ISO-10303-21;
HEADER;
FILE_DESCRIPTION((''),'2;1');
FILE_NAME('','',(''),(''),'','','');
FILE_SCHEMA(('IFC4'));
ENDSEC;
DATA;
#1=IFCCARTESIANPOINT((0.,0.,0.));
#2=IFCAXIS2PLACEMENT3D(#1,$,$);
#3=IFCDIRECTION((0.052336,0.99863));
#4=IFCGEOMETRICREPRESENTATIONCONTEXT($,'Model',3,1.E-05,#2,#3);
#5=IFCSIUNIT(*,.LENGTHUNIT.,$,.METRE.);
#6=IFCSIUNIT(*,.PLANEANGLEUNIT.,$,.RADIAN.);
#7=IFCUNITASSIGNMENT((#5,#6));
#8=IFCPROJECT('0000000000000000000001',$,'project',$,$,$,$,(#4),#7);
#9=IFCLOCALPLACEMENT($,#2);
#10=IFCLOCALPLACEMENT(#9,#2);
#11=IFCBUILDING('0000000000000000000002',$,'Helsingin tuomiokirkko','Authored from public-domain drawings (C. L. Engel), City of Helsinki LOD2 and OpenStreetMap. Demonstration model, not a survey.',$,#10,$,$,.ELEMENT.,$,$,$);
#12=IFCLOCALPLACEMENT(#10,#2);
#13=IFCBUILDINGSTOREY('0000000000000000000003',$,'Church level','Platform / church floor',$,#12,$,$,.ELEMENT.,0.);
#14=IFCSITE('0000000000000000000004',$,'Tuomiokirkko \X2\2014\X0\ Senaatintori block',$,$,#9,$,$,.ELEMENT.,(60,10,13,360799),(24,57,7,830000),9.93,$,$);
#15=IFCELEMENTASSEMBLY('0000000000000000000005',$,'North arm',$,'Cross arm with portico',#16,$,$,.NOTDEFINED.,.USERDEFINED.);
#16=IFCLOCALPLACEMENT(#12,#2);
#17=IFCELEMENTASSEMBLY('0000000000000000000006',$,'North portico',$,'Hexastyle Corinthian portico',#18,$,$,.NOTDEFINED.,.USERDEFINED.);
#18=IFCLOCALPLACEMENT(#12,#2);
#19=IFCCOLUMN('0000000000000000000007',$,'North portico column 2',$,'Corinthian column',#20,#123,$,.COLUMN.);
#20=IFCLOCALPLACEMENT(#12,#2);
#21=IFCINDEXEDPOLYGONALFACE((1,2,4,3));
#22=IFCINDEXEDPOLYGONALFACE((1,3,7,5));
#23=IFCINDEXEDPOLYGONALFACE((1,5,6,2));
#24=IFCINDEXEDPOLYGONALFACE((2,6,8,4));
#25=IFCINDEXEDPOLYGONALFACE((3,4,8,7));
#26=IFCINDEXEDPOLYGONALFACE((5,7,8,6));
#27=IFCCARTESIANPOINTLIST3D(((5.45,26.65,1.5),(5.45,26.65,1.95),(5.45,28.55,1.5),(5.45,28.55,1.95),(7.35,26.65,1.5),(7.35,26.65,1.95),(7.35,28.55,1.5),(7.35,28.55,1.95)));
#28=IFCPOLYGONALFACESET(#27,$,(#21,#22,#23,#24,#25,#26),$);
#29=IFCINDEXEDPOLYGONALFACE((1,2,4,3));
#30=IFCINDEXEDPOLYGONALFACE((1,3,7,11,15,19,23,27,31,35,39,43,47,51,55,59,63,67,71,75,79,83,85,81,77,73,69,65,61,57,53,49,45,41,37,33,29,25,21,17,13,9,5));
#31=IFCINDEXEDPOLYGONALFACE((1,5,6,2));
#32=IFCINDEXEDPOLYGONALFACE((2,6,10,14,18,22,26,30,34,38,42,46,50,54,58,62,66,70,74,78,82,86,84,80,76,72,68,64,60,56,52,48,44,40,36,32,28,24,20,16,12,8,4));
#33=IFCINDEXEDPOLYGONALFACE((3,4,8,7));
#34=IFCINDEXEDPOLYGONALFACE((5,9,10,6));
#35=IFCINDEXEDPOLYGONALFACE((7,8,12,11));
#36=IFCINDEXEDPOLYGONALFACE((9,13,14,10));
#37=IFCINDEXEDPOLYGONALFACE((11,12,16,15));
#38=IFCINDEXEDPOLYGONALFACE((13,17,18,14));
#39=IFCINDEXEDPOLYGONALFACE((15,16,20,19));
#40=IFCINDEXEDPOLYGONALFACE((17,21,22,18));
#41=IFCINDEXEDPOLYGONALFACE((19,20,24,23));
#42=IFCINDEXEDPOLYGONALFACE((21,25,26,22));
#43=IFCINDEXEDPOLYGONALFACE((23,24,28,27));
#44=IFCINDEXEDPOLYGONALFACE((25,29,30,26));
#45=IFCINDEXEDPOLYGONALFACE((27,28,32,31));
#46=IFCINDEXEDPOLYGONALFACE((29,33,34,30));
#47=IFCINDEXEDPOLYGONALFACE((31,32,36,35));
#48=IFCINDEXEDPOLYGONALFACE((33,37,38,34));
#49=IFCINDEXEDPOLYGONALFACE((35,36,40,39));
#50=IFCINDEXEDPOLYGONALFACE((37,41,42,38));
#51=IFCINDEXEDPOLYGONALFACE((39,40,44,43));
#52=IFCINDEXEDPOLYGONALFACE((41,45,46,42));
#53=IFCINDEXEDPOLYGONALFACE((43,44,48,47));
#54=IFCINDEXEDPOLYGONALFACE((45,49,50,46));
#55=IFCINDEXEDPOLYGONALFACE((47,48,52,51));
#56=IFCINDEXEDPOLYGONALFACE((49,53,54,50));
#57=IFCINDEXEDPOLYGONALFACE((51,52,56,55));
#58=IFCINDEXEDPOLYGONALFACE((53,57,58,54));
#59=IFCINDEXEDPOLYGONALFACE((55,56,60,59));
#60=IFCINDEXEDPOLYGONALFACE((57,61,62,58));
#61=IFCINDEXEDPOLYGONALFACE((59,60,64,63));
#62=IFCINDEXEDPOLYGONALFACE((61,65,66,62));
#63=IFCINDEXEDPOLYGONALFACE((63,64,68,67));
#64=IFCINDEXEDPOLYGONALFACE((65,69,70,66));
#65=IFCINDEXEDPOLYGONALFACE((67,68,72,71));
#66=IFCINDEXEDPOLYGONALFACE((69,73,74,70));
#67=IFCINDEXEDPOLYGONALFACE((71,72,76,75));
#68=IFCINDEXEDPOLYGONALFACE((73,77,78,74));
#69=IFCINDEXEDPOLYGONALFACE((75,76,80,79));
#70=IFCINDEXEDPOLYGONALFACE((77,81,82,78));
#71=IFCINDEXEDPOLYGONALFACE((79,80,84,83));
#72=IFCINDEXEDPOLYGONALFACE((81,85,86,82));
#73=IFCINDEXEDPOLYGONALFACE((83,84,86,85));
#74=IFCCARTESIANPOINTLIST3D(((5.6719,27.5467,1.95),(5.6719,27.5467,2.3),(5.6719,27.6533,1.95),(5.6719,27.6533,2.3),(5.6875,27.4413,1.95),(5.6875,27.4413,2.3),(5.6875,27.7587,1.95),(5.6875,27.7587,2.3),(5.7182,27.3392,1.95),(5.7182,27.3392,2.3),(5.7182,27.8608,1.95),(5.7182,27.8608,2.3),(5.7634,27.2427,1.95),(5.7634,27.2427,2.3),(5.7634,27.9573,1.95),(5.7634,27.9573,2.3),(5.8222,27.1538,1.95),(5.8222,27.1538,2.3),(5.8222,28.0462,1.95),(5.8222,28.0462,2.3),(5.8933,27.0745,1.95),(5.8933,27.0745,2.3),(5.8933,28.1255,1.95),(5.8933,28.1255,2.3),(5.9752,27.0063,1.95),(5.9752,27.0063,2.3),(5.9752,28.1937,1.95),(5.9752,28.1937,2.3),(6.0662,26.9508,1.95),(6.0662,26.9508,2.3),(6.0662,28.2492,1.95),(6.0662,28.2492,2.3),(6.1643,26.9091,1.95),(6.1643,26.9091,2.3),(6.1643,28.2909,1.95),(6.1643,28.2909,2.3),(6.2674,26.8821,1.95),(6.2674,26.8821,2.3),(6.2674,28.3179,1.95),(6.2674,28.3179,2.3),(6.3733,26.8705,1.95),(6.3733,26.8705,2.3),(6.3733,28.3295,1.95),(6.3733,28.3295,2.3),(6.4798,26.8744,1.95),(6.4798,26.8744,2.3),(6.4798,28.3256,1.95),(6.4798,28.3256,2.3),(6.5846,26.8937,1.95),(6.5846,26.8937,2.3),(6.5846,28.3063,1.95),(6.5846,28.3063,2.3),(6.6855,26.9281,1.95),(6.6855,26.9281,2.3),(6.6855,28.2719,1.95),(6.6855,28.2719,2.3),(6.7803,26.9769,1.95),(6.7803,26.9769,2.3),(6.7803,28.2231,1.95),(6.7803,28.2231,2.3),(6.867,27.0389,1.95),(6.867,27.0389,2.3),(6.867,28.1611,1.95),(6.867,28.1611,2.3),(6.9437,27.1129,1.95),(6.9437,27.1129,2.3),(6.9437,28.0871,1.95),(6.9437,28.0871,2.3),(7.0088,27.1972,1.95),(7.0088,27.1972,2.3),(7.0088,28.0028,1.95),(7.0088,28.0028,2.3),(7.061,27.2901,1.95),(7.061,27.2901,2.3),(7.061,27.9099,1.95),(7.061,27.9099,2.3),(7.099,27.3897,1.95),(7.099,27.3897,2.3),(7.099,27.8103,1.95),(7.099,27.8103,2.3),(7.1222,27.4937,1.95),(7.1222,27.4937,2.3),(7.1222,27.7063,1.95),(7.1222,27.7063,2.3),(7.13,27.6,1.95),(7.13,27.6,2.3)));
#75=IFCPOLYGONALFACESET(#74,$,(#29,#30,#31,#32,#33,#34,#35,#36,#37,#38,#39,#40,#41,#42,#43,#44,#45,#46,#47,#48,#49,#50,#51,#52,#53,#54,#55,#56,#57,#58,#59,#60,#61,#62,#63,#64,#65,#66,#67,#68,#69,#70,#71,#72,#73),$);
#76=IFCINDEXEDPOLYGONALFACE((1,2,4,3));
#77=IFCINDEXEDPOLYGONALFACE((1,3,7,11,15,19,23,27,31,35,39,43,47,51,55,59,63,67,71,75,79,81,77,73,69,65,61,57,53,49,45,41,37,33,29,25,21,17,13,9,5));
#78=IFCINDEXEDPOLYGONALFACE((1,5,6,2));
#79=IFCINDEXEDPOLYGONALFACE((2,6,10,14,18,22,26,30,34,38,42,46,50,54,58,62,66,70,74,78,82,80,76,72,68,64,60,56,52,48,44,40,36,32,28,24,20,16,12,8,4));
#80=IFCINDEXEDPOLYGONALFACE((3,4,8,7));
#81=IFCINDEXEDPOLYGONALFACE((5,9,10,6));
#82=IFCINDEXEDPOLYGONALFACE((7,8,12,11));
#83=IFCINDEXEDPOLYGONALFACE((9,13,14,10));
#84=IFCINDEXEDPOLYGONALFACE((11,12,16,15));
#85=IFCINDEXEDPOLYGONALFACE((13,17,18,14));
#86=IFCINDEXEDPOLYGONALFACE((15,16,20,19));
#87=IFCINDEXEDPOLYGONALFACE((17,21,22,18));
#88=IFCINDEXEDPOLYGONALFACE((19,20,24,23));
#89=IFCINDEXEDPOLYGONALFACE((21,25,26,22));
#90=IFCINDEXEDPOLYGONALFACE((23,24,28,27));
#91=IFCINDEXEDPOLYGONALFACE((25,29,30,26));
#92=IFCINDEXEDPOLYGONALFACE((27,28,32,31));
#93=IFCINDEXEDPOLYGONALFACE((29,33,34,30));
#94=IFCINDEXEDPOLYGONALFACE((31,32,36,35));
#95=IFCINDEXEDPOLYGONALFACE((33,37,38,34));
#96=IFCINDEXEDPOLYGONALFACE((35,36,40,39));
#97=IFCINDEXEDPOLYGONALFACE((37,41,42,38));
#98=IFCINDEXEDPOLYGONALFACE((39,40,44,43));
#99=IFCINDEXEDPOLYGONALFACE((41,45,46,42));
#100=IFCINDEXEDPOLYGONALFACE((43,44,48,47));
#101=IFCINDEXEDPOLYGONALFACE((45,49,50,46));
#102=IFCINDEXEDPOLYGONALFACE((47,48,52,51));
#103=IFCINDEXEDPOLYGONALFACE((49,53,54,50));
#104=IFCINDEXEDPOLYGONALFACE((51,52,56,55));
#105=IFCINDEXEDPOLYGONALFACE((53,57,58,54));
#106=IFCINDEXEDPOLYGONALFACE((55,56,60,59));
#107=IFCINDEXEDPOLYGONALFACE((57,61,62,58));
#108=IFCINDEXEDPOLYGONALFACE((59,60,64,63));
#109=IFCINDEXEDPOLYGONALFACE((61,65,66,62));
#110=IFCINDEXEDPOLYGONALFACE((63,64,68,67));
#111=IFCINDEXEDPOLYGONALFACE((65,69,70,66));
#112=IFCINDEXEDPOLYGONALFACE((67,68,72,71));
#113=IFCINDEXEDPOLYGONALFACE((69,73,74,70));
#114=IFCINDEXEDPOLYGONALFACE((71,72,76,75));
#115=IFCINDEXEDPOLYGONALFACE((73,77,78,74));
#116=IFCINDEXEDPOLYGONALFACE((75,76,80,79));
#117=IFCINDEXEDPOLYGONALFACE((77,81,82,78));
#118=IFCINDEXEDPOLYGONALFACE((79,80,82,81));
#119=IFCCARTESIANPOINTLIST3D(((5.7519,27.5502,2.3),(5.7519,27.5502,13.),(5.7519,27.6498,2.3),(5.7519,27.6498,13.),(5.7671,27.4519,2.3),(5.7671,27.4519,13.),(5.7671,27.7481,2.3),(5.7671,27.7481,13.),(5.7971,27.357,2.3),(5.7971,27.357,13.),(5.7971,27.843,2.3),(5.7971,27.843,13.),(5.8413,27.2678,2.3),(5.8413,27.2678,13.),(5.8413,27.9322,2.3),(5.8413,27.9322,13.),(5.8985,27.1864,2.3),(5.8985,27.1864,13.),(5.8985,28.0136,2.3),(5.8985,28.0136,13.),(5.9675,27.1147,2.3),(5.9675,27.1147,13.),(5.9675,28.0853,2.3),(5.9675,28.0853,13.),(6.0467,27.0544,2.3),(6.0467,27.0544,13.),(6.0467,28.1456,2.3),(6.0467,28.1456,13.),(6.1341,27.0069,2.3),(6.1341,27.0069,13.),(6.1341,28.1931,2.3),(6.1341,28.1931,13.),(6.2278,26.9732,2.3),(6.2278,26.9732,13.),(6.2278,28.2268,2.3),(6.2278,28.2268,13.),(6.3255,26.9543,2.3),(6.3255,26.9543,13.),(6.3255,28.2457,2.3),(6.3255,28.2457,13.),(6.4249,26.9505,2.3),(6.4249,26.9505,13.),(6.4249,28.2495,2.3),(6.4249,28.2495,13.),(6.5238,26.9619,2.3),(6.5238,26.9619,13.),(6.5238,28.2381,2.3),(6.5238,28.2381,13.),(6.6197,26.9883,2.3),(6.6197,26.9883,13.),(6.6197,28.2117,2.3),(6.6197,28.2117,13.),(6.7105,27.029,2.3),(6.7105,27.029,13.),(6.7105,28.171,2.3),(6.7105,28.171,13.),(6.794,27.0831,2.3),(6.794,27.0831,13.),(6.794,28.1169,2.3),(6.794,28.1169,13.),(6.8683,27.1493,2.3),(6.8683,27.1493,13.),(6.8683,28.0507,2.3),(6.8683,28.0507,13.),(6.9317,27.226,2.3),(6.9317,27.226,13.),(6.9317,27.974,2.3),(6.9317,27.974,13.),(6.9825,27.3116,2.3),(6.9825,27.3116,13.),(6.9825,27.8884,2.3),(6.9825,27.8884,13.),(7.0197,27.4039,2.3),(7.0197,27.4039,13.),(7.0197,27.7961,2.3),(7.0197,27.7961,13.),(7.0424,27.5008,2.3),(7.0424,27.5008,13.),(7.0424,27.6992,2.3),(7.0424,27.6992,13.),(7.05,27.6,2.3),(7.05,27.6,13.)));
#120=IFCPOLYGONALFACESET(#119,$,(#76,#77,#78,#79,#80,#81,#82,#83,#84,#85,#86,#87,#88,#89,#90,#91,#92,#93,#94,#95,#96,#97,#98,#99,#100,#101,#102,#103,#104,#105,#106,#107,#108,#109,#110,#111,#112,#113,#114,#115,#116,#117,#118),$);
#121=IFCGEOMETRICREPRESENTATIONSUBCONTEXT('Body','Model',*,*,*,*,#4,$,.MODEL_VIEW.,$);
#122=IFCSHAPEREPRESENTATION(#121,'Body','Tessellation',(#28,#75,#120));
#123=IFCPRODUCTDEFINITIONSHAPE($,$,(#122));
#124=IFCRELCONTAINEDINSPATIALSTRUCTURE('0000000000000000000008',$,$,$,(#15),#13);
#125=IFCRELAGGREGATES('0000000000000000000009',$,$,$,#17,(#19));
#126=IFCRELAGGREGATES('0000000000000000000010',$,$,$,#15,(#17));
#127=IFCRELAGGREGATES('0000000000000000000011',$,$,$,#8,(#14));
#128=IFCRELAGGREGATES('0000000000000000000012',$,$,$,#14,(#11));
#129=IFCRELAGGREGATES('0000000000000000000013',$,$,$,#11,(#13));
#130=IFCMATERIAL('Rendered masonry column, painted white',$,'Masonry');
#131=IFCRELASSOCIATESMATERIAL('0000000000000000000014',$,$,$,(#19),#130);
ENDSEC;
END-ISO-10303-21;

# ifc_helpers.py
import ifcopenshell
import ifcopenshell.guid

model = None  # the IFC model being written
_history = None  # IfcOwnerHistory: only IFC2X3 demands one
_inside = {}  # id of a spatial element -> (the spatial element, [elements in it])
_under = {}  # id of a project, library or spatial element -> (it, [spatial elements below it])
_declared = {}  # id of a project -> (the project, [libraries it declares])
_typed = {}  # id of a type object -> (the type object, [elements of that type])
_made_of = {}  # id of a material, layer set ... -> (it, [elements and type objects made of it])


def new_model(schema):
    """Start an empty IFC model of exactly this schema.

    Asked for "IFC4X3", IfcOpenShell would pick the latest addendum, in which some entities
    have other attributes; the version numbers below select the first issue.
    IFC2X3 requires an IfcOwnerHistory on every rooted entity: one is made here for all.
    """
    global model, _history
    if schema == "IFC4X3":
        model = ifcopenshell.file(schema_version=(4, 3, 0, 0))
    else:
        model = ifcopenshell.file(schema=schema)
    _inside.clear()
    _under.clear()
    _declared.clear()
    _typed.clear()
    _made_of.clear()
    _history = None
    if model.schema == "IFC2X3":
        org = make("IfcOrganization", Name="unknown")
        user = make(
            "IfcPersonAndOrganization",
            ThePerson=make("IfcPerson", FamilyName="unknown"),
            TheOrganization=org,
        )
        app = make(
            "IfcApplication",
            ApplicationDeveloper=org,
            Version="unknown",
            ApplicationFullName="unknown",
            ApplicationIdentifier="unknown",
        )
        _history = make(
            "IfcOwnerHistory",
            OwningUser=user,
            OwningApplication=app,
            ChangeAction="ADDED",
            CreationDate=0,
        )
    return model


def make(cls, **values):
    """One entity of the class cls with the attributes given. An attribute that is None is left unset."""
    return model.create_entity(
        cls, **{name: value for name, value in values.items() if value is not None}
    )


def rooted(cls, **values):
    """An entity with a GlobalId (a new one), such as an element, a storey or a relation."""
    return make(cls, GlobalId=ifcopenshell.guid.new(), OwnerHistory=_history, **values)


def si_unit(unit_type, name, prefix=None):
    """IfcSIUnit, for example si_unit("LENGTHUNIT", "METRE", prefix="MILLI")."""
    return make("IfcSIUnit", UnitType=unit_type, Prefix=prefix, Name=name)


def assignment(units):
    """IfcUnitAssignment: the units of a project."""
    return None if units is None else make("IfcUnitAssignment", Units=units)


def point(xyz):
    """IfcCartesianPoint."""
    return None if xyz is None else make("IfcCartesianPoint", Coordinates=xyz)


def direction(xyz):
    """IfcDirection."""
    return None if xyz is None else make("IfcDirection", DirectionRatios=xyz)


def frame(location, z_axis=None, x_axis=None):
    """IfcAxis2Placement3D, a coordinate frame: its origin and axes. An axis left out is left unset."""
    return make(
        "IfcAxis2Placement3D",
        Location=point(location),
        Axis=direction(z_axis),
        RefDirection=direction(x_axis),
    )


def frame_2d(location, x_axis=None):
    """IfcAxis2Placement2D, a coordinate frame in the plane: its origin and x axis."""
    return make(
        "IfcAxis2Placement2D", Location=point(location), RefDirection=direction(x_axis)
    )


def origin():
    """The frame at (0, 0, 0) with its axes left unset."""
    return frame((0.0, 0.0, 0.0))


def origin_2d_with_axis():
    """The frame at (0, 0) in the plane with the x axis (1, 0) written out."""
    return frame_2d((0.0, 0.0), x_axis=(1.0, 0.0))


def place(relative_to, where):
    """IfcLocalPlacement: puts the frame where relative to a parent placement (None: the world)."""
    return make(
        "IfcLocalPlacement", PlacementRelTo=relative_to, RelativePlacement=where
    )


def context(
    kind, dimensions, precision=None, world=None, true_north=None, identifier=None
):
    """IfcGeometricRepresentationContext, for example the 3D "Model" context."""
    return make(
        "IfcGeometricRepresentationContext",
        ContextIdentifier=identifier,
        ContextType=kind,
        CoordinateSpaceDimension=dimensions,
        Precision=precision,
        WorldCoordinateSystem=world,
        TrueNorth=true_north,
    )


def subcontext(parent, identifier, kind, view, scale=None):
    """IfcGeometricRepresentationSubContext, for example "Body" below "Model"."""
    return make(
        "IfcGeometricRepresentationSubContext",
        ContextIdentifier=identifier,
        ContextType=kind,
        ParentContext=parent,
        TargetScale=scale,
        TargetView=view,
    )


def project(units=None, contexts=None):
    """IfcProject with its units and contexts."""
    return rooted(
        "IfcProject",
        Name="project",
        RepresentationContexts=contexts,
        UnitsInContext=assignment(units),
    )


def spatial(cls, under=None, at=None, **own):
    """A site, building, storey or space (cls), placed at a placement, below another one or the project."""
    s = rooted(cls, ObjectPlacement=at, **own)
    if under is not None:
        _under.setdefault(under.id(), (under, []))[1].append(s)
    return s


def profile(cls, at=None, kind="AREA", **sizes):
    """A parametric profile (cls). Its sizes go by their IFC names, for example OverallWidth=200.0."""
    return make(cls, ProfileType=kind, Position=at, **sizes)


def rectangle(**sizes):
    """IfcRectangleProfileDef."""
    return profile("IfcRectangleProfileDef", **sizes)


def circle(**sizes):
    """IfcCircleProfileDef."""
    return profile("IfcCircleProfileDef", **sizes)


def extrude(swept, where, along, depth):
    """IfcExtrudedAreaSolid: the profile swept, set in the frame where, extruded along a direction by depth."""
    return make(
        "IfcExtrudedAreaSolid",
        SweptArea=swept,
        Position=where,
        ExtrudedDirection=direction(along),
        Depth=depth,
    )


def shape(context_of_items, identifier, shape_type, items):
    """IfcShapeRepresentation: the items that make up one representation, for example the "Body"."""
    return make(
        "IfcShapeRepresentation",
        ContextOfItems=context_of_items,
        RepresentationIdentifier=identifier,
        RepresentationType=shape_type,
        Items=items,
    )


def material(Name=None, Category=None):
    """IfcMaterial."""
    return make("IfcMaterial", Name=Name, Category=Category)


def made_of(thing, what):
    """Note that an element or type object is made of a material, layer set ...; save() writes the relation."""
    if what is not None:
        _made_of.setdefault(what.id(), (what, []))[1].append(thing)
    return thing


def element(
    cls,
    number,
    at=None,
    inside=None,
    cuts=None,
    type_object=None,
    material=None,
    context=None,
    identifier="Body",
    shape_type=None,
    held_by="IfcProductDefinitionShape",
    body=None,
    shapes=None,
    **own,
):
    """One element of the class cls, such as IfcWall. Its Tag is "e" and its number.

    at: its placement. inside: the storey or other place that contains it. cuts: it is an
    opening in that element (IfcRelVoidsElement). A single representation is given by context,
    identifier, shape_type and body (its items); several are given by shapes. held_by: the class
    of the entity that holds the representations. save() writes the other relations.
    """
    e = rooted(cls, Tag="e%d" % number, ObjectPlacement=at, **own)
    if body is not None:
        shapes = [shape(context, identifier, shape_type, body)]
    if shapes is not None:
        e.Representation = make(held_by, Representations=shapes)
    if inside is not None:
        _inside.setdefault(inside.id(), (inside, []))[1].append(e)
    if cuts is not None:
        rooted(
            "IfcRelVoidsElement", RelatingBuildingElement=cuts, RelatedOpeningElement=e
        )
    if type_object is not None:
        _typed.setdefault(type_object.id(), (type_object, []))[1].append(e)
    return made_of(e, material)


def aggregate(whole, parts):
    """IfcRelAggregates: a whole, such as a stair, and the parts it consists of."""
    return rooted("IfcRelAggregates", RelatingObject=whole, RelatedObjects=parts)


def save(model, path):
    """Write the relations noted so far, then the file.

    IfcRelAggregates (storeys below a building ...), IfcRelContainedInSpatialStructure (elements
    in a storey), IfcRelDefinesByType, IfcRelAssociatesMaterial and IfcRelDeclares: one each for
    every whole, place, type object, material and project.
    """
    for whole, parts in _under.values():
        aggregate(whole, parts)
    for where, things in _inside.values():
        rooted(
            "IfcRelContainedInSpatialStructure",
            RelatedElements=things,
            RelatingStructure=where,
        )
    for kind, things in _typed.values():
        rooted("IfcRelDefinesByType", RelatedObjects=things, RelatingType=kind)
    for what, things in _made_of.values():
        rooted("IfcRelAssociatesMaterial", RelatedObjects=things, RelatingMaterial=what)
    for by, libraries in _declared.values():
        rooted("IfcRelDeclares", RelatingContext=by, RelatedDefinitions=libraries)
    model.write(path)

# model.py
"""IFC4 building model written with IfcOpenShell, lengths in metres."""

from ifc_helpers import new_model, si_unit, direction, frame, origin, origin_2d_with_axis, place, context, subcontext, project, spatial, rectangle, circle, extrude, material, element, aggregate, save


model = new_model("IFC4")

# Units and contexts
model_context = context("Model", 3, precision=1e-05, world=origin(), true_north=direction((0.052336, 0.99863)))
body_context = subcontext(model_context, "Body", "Model", "MODEL_VIEW")
ifc_project = project(units=[si_unit("LENGTHUNIT", "METRE"), si_unit("PLANEANGLEUNIT", "RADIAN")], contexts=[model_context])

# Site, building, storey
site_placement = place(None, origin())
site = spatial("IfcSite", under=ifc_project, at=site_placement, Name="Tuomiokirkko — Senaatintori block", CompositionType="ELEMENT", RefLatitude=(60, 10, 13, 360799), RefLongitude=(24, 57, 7, 830000), RefElevation=9.93)
building_placement = place(site_placement, origin())
building = spatial("IfcBuilding", under=site, at=building_placement, Name="Helsingin tuomiokirkko", Description="Authored from public-domain drawings (C. L. Engel), City of Helsinki LOD2 and OpenStreetMap. Demonstration model, not a survey.", CompositionType="ELEMENT")
storey_placement = place(building_placement, origin())
storey = spatial("IfcBuildingStorey", under=building, at=storey_placement, Name="Church level", Description="Platform / church floor", CompositionType="ELEMENT", Elevation=0.0)

# Element assemblies, column
ifc_material_1 = material(Name="Rendered masonry column, painted white", Category="Masonry")
assembly_1_placement = place(building_placement, origin())
assembly_1 = element("IfcElementAssembly", 1, at=assembly_1_placement, inside=storey, Name="North arm", ObjectType="Cross arm with portico", AssemblyPlace="NOTDEFINED", PredefinedType="USERDEFINED")
assembly_2_placement = place(building_placement, origin())
assembly_2 = element("IfcElementAssembly", 2, at=assembly_2_placement, Name="North portico", ObjectType="Hexastyle Corinthian portico", AssemblyPlace="NOTDEFINED", PredefinedType="USERDEFINED")
column_1_placement = place(building_placement, origin())
column_1 = element("IfcColumn", 3, at=column_1_placement, material=ifc_material_1, Name="North portico column 2", ObjectType="Corinthian column", PredefinedType="COLUMN", context=body_context, shape_type="SweptSolid", body=[
    extrude(rectangle(XDim=1.9, YDim=1.9, at=origin_2d_with_axis()), frame((6.4, 27.6, 1.5)), (0.0, 0.0, 1.0), 0.45),
    extrude(circle(Radius=0.73, at=origin_2d_with_axis()), frame((6.4, 27.6, 1.95)), (0.0, 0.0, 1.0), 0.35),
    extrude(circle(Radius=0.65, at=origin_2d_with_axis()), frame((6.4, 27.6, 2.3)), (0.0, 0.0, 1.0), 10.7),
])

aggregate(assembly_2, [column_1])

aggregate(assembly_1, [assembly_2])

save(model, "model.ifc")
